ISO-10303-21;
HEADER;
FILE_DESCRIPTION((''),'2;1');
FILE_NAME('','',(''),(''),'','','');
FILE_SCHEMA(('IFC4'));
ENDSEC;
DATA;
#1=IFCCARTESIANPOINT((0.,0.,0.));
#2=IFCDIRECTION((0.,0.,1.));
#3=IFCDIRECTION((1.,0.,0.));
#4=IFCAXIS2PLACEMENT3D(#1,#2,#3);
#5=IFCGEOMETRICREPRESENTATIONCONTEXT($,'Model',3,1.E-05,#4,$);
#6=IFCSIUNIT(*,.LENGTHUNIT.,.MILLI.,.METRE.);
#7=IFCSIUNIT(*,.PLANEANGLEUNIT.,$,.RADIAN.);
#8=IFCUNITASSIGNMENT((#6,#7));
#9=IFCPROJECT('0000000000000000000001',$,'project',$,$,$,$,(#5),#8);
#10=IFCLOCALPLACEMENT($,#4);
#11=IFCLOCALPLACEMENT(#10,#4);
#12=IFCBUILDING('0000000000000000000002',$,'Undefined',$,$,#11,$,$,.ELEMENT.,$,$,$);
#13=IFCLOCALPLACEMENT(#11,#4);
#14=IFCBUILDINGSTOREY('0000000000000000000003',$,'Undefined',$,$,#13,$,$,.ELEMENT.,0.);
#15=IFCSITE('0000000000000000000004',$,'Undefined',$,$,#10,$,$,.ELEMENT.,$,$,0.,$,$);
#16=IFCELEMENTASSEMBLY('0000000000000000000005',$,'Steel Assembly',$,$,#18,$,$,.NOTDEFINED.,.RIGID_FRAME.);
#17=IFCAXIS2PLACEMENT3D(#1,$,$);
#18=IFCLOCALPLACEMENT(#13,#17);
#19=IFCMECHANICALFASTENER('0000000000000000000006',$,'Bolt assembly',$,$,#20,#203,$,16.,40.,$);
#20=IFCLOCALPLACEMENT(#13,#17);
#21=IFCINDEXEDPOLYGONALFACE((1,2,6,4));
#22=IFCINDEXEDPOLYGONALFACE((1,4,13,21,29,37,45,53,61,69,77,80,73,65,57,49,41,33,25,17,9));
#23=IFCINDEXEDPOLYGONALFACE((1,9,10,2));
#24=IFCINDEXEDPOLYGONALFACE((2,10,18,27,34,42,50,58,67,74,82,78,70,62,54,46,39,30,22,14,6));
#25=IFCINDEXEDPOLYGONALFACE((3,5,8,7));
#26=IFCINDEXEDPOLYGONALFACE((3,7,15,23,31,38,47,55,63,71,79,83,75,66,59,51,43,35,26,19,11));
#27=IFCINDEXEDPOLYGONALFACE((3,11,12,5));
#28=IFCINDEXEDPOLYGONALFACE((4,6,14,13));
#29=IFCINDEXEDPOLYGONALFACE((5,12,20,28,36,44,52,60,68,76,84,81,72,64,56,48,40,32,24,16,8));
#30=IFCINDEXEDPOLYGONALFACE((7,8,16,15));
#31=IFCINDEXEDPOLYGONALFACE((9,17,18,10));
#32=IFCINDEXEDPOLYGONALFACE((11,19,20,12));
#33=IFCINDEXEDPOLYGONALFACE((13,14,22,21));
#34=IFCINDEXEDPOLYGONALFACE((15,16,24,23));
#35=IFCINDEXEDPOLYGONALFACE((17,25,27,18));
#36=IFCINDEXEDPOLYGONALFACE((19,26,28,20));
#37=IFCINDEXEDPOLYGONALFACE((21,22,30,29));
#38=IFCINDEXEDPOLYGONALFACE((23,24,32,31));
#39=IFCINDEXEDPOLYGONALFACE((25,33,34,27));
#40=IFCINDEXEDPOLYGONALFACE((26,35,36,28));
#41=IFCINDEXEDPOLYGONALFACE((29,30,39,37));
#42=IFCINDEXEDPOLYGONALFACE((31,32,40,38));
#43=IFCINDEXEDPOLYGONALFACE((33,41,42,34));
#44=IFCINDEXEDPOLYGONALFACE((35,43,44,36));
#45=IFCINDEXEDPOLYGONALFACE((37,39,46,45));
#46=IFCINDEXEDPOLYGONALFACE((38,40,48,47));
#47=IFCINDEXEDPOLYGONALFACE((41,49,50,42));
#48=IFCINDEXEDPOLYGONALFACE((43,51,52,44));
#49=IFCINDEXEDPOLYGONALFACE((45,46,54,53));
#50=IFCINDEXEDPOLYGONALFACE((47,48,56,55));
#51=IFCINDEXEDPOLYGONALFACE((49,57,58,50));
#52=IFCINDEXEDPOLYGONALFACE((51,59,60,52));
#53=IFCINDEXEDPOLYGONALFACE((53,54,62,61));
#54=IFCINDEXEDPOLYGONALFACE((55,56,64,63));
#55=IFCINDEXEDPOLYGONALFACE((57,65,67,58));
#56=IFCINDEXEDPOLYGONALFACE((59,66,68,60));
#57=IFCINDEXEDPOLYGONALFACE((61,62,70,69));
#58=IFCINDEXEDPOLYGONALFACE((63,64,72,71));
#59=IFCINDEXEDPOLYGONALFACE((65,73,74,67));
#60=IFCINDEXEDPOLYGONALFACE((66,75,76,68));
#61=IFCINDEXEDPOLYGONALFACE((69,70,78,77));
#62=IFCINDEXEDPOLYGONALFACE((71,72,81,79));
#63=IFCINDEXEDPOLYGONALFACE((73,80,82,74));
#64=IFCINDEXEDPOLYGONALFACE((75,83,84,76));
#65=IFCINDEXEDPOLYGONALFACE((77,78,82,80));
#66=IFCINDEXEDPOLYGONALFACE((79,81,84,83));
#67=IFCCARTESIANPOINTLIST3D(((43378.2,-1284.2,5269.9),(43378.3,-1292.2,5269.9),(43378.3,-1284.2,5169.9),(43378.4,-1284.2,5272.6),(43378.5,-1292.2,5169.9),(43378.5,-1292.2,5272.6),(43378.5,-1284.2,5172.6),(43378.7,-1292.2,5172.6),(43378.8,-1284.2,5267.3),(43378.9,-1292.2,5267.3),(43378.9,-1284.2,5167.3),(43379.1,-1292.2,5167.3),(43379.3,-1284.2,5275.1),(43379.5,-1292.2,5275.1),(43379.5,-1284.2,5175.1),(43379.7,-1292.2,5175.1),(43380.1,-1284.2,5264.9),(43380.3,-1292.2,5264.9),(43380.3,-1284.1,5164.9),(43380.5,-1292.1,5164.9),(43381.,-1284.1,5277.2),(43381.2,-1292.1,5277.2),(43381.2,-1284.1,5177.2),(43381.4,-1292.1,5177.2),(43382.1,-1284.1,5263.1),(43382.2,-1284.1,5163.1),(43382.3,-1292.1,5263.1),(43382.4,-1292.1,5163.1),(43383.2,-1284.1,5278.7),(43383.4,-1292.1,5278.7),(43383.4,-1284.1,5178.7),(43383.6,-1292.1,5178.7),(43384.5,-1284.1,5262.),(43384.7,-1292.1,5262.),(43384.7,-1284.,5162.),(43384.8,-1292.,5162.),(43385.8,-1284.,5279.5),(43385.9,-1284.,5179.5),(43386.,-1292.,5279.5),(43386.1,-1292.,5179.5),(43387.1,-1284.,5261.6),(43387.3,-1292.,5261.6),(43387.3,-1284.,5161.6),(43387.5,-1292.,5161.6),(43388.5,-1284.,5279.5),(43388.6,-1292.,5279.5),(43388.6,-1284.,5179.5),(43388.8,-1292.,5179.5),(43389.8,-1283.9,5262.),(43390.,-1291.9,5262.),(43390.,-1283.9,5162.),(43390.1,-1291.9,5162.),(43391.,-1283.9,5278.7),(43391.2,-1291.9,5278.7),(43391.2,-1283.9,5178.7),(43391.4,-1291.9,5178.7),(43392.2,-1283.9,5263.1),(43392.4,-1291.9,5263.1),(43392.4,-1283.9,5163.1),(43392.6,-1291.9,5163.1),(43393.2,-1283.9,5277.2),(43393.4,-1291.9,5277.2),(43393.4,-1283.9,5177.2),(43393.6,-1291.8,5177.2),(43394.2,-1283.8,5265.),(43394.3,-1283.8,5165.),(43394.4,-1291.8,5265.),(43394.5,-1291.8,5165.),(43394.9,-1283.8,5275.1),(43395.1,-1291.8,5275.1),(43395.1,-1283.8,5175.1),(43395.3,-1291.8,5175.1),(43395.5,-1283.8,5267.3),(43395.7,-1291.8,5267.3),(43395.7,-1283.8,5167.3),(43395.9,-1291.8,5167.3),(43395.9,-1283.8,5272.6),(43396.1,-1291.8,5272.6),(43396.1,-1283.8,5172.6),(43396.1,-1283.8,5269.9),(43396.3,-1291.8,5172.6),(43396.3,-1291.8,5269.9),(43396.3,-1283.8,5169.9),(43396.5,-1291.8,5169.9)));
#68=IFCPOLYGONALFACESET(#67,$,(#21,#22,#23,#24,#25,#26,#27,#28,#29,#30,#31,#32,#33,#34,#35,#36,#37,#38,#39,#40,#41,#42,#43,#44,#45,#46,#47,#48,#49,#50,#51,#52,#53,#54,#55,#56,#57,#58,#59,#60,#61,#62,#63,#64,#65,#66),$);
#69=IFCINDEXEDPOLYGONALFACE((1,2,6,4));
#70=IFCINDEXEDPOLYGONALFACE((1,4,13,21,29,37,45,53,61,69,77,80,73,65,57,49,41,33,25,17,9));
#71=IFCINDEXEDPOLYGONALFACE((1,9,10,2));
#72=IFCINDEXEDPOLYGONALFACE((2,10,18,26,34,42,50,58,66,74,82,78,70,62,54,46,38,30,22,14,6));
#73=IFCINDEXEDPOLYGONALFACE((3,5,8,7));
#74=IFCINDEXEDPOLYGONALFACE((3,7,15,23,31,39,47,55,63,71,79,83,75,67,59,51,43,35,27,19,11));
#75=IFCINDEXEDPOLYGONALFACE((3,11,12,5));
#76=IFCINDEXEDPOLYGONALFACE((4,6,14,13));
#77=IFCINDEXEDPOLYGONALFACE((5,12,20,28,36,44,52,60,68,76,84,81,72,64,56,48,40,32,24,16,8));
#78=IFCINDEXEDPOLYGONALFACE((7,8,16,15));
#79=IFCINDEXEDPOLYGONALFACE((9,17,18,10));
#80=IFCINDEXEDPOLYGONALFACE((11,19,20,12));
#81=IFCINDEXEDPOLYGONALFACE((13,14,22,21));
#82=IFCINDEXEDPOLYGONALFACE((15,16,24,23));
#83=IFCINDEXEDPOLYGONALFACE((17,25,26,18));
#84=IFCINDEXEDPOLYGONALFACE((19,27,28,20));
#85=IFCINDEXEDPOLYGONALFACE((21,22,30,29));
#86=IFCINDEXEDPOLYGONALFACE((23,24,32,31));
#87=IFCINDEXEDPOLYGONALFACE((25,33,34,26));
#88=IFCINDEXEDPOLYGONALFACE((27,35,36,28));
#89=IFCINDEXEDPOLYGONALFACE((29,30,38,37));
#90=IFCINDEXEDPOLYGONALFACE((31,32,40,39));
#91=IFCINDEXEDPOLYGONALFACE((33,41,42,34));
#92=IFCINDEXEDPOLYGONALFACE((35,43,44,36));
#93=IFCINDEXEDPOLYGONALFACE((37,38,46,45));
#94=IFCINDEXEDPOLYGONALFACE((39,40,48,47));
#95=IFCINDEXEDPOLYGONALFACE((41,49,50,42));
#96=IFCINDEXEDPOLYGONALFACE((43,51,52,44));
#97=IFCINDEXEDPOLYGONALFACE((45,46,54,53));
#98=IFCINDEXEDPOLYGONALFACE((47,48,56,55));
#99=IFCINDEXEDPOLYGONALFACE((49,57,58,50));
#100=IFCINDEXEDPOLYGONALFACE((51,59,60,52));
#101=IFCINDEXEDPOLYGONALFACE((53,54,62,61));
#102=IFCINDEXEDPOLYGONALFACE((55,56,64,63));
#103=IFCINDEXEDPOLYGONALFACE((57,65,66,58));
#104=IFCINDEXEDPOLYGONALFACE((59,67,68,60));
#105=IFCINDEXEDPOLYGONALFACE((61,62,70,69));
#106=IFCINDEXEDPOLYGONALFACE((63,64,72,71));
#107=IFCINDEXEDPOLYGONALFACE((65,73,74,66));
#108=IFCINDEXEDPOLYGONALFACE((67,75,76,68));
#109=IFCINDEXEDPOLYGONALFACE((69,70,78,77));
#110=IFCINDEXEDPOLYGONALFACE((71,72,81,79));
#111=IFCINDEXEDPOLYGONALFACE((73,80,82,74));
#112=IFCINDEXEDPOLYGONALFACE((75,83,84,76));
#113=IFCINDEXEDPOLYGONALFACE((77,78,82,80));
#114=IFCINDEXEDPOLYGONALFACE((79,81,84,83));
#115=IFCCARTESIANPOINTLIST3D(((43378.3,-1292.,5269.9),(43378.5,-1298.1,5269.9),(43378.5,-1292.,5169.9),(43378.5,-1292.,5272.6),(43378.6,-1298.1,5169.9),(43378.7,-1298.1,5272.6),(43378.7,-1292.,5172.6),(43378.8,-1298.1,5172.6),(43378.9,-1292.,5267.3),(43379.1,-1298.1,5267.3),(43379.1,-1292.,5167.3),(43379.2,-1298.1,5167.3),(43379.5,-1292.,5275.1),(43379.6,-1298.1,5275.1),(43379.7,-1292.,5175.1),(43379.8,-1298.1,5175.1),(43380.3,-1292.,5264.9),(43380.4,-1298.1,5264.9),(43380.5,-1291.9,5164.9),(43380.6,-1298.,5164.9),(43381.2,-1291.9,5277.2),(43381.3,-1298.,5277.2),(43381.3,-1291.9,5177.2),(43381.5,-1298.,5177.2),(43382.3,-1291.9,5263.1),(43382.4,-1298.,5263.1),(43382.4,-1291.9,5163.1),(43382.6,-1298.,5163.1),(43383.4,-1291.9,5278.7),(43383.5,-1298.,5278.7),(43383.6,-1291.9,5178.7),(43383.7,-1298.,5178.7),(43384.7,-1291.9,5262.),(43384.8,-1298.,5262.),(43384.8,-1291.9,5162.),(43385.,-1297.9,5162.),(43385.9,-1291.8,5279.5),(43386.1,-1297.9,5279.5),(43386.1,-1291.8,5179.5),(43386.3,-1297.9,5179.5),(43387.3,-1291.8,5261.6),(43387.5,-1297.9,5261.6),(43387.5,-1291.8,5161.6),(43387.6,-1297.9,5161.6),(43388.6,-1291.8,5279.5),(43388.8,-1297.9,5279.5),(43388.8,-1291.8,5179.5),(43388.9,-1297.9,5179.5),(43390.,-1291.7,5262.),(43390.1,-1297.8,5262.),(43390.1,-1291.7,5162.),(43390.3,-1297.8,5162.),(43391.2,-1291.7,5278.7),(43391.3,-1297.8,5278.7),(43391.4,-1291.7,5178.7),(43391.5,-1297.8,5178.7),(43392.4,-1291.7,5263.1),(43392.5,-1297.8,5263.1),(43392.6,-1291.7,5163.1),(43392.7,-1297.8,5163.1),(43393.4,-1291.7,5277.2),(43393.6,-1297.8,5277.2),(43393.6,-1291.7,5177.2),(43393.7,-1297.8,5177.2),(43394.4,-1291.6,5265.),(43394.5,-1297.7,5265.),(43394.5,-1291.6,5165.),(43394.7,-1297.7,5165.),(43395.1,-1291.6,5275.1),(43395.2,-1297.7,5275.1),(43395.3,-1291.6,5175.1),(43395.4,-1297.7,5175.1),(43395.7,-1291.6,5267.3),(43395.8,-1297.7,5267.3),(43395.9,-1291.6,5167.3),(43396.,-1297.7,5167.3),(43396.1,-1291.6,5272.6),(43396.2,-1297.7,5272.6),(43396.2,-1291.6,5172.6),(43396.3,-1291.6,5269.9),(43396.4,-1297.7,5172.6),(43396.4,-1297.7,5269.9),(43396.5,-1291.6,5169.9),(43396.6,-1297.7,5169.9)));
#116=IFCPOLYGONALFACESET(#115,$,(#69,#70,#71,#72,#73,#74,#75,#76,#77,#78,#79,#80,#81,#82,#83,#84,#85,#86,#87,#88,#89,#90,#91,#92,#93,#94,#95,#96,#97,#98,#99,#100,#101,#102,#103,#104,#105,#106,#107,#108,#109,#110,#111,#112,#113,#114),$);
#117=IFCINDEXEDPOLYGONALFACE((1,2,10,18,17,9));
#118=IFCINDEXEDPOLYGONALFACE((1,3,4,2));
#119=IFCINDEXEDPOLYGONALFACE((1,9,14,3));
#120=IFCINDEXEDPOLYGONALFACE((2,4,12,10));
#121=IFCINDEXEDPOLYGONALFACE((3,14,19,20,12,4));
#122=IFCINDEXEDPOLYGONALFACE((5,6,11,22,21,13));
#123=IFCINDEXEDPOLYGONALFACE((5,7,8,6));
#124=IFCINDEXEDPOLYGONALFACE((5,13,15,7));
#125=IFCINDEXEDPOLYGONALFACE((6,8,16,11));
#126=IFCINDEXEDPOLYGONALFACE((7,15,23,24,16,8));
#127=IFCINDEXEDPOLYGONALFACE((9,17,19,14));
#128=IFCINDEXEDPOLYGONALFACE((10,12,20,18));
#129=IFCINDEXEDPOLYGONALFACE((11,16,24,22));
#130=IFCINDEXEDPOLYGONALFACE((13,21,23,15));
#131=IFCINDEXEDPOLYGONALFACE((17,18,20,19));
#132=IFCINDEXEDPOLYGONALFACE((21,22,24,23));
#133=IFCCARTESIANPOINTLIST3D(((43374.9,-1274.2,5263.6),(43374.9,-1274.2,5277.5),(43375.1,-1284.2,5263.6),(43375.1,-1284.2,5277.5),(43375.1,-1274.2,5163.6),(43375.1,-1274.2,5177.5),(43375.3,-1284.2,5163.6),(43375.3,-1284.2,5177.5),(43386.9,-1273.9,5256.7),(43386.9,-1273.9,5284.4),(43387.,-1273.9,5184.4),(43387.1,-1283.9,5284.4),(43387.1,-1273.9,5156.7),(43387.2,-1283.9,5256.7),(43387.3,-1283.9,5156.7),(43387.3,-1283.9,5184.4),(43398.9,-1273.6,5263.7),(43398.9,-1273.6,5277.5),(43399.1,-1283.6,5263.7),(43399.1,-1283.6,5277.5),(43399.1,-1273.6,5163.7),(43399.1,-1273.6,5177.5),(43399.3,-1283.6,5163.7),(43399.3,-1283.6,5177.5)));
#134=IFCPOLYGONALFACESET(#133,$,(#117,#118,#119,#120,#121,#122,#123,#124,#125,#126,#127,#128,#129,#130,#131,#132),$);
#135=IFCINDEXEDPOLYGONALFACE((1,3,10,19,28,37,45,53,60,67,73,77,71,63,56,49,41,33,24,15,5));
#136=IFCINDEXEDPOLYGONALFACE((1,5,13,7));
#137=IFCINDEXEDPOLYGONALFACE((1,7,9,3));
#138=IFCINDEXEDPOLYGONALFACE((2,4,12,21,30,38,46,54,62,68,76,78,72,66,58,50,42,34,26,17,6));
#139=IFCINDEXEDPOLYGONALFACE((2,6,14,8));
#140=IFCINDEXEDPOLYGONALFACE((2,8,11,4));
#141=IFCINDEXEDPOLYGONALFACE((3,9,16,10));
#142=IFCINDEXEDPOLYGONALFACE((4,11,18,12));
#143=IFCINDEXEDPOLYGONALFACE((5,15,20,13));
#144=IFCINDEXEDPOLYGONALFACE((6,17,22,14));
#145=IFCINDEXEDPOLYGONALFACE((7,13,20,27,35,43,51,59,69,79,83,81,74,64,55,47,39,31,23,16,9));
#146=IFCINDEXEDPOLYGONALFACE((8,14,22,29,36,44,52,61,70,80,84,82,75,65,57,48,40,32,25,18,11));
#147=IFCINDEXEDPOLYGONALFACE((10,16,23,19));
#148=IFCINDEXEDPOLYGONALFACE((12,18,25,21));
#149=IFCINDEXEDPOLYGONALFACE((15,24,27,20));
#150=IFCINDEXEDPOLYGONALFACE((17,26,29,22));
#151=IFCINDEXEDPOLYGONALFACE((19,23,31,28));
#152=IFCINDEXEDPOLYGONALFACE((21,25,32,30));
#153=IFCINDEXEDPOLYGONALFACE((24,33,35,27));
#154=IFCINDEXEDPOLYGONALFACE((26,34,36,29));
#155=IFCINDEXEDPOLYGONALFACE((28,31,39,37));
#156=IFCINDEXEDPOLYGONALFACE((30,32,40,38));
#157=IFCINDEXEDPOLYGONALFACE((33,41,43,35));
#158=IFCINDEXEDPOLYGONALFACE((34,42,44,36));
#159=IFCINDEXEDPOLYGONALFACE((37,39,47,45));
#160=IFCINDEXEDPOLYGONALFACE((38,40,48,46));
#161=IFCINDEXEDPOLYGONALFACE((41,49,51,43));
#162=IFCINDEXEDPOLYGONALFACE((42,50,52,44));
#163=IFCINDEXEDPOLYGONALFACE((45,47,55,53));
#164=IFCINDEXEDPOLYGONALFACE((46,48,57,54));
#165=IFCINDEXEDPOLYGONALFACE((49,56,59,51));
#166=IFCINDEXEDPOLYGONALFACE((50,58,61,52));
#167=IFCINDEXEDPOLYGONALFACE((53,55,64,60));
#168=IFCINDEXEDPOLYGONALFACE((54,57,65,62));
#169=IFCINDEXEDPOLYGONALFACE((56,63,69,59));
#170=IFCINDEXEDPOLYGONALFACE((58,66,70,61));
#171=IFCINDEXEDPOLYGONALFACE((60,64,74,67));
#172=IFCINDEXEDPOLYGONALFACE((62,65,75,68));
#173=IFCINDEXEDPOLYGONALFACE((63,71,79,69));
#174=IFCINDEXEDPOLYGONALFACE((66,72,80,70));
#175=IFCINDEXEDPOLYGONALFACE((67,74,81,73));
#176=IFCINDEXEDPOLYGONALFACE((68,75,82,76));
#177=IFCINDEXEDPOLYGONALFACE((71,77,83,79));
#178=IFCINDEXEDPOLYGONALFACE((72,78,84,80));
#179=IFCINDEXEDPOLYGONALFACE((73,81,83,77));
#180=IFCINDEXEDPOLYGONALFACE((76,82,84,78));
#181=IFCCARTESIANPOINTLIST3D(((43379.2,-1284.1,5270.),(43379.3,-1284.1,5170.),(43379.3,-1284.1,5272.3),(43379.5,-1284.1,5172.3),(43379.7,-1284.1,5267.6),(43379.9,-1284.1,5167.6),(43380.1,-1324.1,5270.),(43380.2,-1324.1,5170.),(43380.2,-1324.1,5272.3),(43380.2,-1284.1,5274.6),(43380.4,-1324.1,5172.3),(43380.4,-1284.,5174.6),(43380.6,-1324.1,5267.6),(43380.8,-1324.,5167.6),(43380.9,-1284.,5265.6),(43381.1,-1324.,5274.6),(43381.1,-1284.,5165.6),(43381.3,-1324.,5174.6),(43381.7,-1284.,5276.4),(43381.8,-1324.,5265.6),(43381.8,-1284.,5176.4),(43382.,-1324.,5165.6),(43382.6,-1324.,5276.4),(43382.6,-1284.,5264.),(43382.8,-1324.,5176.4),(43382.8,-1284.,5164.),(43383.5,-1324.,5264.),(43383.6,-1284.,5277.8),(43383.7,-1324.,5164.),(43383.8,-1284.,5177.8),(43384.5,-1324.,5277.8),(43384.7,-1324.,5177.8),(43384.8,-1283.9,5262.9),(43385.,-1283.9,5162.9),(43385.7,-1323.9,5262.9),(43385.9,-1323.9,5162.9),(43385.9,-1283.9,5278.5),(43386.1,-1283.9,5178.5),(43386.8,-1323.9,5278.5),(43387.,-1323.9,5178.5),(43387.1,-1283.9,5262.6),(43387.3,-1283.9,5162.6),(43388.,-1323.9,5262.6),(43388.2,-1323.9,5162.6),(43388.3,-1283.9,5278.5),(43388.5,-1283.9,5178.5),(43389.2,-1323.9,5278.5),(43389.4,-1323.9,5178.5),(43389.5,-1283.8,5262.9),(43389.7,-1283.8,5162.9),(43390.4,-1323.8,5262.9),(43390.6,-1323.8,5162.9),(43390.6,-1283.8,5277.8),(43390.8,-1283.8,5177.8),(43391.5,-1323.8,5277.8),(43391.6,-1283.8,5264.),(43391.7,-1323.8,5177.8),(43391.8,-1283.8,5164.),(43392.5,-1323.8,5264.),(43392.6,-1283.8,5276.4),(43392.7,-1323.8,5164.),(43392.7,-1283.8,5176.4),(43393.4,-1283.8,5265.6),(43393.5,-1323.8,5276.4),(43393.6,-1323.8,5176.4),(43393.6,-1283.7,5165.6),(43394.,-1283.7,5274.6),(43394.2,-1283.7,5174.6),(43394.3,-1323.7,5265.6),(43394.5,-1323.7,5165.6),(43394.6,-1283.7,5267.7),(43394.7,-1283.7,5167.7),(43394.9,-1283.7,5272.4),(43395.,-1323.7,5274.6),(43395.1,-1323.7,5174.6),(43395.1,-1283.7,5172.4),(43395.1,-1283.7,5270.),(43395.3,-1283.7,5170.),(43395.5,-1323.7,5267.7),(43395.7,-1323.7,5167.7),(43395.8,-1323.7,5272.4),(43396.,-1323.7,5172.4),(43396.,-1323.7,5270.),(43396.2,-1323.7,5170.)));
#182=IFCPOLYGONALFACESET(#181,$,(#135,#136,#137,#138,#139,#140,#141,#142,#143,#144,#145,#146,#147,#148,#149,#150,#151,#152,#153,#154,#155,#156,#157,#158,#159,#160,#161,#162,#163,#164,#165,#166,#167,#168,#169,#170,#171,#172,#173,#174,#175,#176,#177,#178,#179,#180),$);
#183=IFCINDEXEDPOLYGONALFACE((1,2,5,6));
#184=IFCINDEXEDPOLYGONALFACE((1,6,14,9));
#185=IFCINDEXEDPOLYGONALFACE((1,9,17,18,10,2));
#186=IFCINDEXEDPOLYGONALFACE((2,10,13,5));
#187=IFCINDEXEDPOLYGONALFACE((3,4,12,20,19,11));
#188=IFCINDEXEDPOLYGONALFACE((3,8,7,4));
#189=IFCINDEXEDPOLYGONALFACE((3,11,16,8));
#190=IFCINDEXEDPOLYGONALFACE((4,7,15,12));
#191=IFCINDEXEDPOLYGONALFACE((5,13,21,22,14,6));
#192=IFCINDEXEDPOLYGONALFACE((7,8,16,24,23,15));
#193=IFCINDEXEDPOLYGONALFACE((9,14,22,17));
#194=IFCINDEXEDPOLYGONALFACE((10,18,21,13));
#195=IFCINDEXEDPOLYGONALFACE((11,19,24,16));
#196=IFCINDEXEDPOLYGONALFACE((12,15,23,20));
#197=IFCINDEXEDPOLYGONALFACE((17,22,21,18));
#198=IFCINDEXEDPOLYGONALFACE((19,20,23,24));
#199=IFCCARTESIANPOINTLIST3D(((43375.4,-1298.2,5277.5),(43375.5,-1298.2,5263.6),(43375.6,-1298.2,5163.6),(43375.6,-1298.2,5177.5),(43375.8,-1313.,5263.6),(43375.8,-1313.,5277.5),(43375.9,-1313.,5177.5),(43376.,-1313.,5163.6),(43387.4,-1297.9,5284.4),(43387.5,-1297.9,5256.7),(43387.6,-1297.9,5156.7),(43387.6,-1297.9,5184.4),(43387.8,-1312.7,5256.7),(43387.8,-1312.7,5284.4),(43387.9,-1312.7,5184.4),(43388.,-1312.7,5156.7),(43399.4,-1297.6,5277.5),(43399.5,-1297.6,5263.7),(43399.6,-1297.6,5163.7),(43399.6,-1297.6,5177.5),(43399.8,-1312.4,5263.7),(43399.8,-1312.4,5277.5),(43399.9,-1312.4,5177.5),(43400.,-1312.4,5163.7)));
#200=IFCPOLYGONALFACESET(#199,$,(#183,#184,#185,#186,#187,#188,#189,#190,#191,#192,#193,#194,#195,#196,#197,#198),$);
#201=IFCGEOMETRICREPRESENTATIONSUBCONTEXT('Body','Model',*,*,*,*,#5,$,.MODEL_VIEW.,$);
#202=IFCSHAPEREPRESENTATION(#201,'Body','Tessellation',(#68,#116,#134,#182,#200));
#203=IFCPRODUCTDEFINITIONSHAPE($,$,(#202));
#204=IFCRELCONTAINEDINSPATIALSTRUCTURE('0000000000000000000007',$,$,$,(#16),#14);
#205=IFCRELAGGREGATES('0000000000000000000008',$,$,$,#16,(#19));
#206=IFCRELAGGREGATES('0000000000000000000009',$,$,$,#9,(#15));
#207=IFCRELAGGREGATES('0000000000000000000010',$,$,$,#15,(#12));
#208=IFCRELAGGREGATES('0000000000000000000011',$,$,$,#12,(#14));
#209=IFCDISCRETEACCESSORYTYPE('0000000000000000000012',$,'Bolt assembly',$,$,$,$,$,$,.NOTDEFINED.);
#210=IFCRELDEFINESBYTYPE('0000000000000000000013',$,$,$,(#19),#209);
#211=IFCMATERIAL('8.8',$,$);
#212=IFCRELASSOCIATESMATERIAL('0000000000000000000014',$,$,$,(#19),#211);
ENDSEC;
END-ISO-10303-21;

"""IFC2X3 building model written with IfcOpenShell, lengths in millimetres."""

from ifc_helpers import new_model, si_unit, frame, origin_with_axes, origin_2d_with_axis, place, context, subcontext, project, spatial, polyline, circle, outline, extrude, source, transform, mapped, material, type_object, element, aggregate, save


model = new_model("IFC2X3")

# Units and contexts
model_context = context("Model", 3, precision=1e-05, world=origin_with_axes())
body_context = subcontext(model_context, "Body", "Model", "MODEL_VIEW")
ifc_project = project(units=[si_unit("LENGTHUNIT", "METRE", prefix="MILLI"), si_unit("PLANEANGLEUNIT", "RADIAN")], contexts=[model_context])

# Site, building, storey
site_placement = place(None, origin_with_axes())
site = spatial("IfcSite", under=ifc_project, at=site_placement, Name="Undefined", CompositionType="ELEMENT", RefElevation=0.0)
building_placement = place(site_placement, origin_with_axes())
building = spatial("IfcBuilding", under=site, at=building_placement, Name="Undefined", CompositionType="ELEMENT")
storey_placement = place(building_placement, origin_with_axes())
storey = spatial("IfcBuildingStorey", under=building, at=storey_placement, Name="Undefined", CompositionType="ELEMENT", Elevation=0.0)

# Element assembly
assembly_1_placement = place(storey_placement, origin_with_axes())
assembly_1 = element("IfcElementAssembly", 1, at=assembly_1_placement, inside=storey, Name="Steel Assembly", AssemblyPlace="NOTDEFINED", PredefinedType="RIGID_FRAME")

# Shared definitions
discrete_accessory_type_1 = type_object("IfcDiscreteAccessoryType", Name="Bolt assembly")

# Shared definitions
ifc_material_1 = material(Name="8.8")

# Mechanical fastener
shared_shape_1 = source(origin_with_axes(), body_context, "Body", "SweptSolid", [
    extrude(circle(Radius=9.0, at=origin_2d_with_axis()), frame((0.0, -7.9, 0.0), z_axis=(0.0, 1.0, 0.0), x_axis=(1.0, 0.0, 0.0)), (0.0, 0.0, 1.0), 8.0),
    extrude(circle(Radius=9.0, at=origin_2d_with_axis()), frame((0.0, -0.1, 0.0), z_axis=(0.0, 1.0, 0.0), x_axis=(1.0, 0.0, 0.0)), (0.0, 0.0, 1.0), 6.1),
    extrude(outline(polyline([(13.9, 0.0), (6.9, 12.0), (-6.9, 12.0), (-13.9, 0.0), (-6.9, -12.0), (6.9, -12.0), (13.9, 0.0)])), frame((0.0, -18.0, 0.0), z_axis=(0.0, 1.0, 0.0), x_axis=(1.0, 0.0, 0.0)), (0.0, 0.0, 1.0), 10.0),
    extrude(circle(Radius=8.0, at=origin_2d_with_axis()), frame((0.0, -8.0, 0.0), z_axis=(0.0, 1.0, 0.0), x_axis=(1.0, 0.0, 0.0)), (0.0, 0.0, 1.0), 40.0),
    extrude(outline(polyline([(13.9, 0.0), (6.9, 12.0), (-6.9, 12.0), (-13.9, 0.0), (-6.9, -12.0), (6.9, -12.0), (13.9, 0.0)])), frame((0.0, 6.0, 0.0), z_axis=(0.0, 1.0, 0.0), x_axis=(1.0, 0.0, 0.0)), (0.0, 0.0, 1.0), 14.8),
])
mechanical_fastener_1_placement = place(assembly_1_placement, frame((43387.3, -1291.9, 5270.6), z_axis=(-0.999743, -0.022588, -0.001724), x_axis=(0.001722, 0.000078, -0.999999)))
mechanical_fastener_1 = element("IfcMechanicalFastener", 2, at=mechanical_fastener_1_placement, type_object=discrete_accessory_type_1, material=ifc_material_1, Name="Bolt assembly", NominalDiameter=16.0, NominalLength=40.0, context=body_context, shape_type="MappedRepresentation", body=[
    mapped(shared_shape_1, transform((0.0, 0.0, 0.0))),
    mapped(shared_shape_1, transform((100.0, 0.0, 0.0))),
])

aggregate(assembly_1, [mechanical_fastener_1])

save(model, "model.ifc")
